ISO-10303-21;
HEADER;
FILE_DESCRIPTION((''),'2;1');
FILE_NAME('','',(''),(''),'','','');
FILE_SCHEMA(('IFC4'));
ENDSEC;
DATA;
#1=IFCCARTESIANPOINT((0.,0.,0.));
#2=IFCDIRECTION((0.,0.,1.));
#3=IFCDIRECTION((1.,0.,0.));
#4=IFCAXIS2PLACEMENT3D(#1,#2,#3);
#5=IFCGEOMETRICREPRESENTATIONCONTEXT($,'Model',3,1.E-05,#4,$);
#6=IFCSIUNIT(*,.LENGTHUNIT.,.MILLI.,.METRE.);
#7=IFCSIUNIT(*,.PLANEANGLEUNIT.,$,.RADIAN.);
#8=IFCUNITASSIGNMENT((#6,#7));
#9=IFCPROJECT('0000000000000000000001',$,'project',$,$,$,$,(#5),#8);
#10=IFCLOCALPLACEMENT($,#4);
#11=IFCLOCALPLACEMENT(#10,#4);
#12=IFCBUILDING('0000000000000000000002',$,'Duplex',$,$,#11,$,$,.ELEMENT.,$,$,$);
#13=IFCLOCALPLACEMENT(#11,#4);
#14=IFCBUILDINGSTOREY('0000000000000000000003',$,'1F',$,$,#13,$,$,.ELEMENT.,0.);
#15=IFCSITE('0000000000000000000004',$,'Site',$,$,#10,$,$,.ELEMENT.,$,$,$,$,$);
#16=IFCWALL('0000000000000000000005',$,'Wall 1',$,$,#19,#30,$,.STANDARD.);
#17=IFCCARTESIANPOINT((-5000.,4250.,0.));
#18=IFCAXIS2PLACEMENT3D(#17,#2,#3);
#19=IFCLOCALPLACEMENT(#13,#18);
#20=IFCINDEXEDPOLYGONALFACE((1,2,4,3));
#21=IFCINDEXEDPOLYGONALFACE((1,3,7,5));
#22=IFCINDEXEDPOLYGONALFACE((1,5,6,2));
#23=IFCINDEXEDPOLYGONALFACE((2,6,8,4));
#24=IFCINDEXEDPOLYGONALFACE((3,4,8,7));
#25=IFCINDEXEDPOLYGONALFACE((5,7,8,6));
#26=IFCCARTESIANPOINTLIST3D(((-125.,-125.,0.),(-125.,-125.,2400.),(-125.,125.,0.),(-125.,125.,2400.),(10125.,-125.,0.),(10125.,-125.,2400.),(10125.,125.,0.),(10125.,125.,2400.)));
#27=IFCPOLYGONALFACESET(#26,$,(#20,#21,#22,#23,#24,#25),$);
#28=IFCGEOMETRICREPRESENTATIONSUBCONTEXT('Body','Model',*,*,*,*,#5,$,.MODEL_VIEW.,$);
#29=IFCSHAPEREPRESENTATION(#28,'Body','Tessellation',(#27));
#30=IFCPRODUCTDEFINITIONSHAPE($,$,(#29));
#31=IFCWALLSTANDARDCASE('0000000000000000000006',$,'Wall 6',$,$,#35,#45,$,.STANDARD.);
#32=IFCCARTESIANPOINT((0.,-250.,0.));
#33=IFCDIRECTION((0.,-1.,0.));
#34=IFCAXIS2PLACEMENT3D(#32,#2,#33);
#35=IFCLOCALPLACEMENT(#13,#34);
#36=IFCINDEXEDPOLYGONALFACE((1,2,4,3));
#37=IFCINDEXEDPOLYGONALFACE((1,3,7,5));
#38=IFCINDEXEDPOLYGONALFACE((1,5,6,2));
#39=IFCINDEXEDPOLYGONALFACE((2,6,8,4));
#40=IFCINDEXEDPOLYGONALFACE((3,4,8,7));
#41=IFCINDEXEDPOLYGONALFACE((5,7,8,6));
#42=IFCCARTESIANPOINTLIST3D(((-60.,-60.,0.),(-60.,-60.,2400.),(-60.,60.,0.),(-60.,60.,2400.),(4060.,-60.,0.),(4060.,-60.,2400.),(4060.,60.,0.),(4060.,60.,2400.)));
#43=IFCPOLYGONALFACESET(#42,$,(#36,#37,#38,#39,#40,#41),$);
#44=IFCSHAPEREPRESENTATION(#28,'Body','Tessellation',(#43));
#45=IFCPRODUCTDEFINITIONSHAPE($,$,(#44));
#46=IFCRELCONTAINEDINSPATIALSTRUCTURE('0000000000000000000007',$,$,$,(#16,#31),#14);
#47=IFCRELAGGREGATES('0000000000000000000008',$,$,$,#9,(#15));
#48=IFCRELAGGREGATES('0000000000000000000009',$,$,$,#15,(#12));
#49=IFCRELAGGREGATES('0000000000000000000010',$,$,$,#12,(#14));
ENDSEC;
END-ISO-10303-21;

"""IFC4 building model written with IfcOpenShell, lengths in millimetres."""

from ifc_helpers import new_model, si_unit, frame, frame_2d, origin, origin_with_axes, place, context, subcontext, project, spatial, rectangle, extrude, element, save


model = new_model("IFC4")

# Units and contexts
model_context = context("Model", 3, precision=1e-05, world=origin_with_axes())
body_context = subcontext(model_context, "Body", "Model", "MODEL_VIEW")
ifc_project = project(units=[si_unit("LENGTHUNIT", "METRE", prefix="MILLI"), si_unit("PLANEANGLEUNIT", "RADIAN")], contexts=[model_context])

# Site, building, storey
site_placement = place(None, origin_with_axes())
site = spatial("IfcSite", under=ifc_project, at=site_placement, Name="Site", CompositionType="ELEMENT")
building_placement = place(site_placement, origin_with_axes())
building = spatial("IfcBuilding", under=site, at=building_placement, Name="Duplex", CompositionType="ELEMENT")
storey_placement = place(building_placement, origin_with_axes())
storey = spatial("IfcBuildingStorey", under=building, at=storey_placement, Name="1F", CompositionType="ELEMENT", Elevation=0.0)

# Wall
wall_1_placement = place(storey_placement, frame((-5000.0, 4250.0, 0.0), z_axis=(0.0, 0.0, 1.0), x_axis=(1.0, 0.0, 0.0)))
element("IfcWall", 1, at=wall_1_placement, inside=storey, Name="Wall 1", PredefinedType="STANDARD", context=body_context, shape_type="SweptSolid", body=[
    extrude(rectangle(XDim=10250.0, YDim=250.0, at=frame_2d((5000.0, 0.0))), origin(), (0.0, 0.0, 1.0), 2400.0),
])

# Wall
wall_2_placement = place(storey_placement, frame((0.0, -250.0, 0.0), z_axis=(0.0, 0.0, 1.0), x_axis=(0.0, -1.0, 0.0)))
element("IfcWallStandardCase", 2, at=wall_2_placement, inside=storey, Name="Wall 6", PredefinedType="STANDARD", context=body_context, shape_type="SweptSolid", body=[
    extrude(rectangle(XDim=4120.0, YDim=120.0, at=frame_2d((2000.0, 0.0))), origin(), (0.0, 0.0, 1.0), 2400.0),
])

save(model, "model.ifc")
